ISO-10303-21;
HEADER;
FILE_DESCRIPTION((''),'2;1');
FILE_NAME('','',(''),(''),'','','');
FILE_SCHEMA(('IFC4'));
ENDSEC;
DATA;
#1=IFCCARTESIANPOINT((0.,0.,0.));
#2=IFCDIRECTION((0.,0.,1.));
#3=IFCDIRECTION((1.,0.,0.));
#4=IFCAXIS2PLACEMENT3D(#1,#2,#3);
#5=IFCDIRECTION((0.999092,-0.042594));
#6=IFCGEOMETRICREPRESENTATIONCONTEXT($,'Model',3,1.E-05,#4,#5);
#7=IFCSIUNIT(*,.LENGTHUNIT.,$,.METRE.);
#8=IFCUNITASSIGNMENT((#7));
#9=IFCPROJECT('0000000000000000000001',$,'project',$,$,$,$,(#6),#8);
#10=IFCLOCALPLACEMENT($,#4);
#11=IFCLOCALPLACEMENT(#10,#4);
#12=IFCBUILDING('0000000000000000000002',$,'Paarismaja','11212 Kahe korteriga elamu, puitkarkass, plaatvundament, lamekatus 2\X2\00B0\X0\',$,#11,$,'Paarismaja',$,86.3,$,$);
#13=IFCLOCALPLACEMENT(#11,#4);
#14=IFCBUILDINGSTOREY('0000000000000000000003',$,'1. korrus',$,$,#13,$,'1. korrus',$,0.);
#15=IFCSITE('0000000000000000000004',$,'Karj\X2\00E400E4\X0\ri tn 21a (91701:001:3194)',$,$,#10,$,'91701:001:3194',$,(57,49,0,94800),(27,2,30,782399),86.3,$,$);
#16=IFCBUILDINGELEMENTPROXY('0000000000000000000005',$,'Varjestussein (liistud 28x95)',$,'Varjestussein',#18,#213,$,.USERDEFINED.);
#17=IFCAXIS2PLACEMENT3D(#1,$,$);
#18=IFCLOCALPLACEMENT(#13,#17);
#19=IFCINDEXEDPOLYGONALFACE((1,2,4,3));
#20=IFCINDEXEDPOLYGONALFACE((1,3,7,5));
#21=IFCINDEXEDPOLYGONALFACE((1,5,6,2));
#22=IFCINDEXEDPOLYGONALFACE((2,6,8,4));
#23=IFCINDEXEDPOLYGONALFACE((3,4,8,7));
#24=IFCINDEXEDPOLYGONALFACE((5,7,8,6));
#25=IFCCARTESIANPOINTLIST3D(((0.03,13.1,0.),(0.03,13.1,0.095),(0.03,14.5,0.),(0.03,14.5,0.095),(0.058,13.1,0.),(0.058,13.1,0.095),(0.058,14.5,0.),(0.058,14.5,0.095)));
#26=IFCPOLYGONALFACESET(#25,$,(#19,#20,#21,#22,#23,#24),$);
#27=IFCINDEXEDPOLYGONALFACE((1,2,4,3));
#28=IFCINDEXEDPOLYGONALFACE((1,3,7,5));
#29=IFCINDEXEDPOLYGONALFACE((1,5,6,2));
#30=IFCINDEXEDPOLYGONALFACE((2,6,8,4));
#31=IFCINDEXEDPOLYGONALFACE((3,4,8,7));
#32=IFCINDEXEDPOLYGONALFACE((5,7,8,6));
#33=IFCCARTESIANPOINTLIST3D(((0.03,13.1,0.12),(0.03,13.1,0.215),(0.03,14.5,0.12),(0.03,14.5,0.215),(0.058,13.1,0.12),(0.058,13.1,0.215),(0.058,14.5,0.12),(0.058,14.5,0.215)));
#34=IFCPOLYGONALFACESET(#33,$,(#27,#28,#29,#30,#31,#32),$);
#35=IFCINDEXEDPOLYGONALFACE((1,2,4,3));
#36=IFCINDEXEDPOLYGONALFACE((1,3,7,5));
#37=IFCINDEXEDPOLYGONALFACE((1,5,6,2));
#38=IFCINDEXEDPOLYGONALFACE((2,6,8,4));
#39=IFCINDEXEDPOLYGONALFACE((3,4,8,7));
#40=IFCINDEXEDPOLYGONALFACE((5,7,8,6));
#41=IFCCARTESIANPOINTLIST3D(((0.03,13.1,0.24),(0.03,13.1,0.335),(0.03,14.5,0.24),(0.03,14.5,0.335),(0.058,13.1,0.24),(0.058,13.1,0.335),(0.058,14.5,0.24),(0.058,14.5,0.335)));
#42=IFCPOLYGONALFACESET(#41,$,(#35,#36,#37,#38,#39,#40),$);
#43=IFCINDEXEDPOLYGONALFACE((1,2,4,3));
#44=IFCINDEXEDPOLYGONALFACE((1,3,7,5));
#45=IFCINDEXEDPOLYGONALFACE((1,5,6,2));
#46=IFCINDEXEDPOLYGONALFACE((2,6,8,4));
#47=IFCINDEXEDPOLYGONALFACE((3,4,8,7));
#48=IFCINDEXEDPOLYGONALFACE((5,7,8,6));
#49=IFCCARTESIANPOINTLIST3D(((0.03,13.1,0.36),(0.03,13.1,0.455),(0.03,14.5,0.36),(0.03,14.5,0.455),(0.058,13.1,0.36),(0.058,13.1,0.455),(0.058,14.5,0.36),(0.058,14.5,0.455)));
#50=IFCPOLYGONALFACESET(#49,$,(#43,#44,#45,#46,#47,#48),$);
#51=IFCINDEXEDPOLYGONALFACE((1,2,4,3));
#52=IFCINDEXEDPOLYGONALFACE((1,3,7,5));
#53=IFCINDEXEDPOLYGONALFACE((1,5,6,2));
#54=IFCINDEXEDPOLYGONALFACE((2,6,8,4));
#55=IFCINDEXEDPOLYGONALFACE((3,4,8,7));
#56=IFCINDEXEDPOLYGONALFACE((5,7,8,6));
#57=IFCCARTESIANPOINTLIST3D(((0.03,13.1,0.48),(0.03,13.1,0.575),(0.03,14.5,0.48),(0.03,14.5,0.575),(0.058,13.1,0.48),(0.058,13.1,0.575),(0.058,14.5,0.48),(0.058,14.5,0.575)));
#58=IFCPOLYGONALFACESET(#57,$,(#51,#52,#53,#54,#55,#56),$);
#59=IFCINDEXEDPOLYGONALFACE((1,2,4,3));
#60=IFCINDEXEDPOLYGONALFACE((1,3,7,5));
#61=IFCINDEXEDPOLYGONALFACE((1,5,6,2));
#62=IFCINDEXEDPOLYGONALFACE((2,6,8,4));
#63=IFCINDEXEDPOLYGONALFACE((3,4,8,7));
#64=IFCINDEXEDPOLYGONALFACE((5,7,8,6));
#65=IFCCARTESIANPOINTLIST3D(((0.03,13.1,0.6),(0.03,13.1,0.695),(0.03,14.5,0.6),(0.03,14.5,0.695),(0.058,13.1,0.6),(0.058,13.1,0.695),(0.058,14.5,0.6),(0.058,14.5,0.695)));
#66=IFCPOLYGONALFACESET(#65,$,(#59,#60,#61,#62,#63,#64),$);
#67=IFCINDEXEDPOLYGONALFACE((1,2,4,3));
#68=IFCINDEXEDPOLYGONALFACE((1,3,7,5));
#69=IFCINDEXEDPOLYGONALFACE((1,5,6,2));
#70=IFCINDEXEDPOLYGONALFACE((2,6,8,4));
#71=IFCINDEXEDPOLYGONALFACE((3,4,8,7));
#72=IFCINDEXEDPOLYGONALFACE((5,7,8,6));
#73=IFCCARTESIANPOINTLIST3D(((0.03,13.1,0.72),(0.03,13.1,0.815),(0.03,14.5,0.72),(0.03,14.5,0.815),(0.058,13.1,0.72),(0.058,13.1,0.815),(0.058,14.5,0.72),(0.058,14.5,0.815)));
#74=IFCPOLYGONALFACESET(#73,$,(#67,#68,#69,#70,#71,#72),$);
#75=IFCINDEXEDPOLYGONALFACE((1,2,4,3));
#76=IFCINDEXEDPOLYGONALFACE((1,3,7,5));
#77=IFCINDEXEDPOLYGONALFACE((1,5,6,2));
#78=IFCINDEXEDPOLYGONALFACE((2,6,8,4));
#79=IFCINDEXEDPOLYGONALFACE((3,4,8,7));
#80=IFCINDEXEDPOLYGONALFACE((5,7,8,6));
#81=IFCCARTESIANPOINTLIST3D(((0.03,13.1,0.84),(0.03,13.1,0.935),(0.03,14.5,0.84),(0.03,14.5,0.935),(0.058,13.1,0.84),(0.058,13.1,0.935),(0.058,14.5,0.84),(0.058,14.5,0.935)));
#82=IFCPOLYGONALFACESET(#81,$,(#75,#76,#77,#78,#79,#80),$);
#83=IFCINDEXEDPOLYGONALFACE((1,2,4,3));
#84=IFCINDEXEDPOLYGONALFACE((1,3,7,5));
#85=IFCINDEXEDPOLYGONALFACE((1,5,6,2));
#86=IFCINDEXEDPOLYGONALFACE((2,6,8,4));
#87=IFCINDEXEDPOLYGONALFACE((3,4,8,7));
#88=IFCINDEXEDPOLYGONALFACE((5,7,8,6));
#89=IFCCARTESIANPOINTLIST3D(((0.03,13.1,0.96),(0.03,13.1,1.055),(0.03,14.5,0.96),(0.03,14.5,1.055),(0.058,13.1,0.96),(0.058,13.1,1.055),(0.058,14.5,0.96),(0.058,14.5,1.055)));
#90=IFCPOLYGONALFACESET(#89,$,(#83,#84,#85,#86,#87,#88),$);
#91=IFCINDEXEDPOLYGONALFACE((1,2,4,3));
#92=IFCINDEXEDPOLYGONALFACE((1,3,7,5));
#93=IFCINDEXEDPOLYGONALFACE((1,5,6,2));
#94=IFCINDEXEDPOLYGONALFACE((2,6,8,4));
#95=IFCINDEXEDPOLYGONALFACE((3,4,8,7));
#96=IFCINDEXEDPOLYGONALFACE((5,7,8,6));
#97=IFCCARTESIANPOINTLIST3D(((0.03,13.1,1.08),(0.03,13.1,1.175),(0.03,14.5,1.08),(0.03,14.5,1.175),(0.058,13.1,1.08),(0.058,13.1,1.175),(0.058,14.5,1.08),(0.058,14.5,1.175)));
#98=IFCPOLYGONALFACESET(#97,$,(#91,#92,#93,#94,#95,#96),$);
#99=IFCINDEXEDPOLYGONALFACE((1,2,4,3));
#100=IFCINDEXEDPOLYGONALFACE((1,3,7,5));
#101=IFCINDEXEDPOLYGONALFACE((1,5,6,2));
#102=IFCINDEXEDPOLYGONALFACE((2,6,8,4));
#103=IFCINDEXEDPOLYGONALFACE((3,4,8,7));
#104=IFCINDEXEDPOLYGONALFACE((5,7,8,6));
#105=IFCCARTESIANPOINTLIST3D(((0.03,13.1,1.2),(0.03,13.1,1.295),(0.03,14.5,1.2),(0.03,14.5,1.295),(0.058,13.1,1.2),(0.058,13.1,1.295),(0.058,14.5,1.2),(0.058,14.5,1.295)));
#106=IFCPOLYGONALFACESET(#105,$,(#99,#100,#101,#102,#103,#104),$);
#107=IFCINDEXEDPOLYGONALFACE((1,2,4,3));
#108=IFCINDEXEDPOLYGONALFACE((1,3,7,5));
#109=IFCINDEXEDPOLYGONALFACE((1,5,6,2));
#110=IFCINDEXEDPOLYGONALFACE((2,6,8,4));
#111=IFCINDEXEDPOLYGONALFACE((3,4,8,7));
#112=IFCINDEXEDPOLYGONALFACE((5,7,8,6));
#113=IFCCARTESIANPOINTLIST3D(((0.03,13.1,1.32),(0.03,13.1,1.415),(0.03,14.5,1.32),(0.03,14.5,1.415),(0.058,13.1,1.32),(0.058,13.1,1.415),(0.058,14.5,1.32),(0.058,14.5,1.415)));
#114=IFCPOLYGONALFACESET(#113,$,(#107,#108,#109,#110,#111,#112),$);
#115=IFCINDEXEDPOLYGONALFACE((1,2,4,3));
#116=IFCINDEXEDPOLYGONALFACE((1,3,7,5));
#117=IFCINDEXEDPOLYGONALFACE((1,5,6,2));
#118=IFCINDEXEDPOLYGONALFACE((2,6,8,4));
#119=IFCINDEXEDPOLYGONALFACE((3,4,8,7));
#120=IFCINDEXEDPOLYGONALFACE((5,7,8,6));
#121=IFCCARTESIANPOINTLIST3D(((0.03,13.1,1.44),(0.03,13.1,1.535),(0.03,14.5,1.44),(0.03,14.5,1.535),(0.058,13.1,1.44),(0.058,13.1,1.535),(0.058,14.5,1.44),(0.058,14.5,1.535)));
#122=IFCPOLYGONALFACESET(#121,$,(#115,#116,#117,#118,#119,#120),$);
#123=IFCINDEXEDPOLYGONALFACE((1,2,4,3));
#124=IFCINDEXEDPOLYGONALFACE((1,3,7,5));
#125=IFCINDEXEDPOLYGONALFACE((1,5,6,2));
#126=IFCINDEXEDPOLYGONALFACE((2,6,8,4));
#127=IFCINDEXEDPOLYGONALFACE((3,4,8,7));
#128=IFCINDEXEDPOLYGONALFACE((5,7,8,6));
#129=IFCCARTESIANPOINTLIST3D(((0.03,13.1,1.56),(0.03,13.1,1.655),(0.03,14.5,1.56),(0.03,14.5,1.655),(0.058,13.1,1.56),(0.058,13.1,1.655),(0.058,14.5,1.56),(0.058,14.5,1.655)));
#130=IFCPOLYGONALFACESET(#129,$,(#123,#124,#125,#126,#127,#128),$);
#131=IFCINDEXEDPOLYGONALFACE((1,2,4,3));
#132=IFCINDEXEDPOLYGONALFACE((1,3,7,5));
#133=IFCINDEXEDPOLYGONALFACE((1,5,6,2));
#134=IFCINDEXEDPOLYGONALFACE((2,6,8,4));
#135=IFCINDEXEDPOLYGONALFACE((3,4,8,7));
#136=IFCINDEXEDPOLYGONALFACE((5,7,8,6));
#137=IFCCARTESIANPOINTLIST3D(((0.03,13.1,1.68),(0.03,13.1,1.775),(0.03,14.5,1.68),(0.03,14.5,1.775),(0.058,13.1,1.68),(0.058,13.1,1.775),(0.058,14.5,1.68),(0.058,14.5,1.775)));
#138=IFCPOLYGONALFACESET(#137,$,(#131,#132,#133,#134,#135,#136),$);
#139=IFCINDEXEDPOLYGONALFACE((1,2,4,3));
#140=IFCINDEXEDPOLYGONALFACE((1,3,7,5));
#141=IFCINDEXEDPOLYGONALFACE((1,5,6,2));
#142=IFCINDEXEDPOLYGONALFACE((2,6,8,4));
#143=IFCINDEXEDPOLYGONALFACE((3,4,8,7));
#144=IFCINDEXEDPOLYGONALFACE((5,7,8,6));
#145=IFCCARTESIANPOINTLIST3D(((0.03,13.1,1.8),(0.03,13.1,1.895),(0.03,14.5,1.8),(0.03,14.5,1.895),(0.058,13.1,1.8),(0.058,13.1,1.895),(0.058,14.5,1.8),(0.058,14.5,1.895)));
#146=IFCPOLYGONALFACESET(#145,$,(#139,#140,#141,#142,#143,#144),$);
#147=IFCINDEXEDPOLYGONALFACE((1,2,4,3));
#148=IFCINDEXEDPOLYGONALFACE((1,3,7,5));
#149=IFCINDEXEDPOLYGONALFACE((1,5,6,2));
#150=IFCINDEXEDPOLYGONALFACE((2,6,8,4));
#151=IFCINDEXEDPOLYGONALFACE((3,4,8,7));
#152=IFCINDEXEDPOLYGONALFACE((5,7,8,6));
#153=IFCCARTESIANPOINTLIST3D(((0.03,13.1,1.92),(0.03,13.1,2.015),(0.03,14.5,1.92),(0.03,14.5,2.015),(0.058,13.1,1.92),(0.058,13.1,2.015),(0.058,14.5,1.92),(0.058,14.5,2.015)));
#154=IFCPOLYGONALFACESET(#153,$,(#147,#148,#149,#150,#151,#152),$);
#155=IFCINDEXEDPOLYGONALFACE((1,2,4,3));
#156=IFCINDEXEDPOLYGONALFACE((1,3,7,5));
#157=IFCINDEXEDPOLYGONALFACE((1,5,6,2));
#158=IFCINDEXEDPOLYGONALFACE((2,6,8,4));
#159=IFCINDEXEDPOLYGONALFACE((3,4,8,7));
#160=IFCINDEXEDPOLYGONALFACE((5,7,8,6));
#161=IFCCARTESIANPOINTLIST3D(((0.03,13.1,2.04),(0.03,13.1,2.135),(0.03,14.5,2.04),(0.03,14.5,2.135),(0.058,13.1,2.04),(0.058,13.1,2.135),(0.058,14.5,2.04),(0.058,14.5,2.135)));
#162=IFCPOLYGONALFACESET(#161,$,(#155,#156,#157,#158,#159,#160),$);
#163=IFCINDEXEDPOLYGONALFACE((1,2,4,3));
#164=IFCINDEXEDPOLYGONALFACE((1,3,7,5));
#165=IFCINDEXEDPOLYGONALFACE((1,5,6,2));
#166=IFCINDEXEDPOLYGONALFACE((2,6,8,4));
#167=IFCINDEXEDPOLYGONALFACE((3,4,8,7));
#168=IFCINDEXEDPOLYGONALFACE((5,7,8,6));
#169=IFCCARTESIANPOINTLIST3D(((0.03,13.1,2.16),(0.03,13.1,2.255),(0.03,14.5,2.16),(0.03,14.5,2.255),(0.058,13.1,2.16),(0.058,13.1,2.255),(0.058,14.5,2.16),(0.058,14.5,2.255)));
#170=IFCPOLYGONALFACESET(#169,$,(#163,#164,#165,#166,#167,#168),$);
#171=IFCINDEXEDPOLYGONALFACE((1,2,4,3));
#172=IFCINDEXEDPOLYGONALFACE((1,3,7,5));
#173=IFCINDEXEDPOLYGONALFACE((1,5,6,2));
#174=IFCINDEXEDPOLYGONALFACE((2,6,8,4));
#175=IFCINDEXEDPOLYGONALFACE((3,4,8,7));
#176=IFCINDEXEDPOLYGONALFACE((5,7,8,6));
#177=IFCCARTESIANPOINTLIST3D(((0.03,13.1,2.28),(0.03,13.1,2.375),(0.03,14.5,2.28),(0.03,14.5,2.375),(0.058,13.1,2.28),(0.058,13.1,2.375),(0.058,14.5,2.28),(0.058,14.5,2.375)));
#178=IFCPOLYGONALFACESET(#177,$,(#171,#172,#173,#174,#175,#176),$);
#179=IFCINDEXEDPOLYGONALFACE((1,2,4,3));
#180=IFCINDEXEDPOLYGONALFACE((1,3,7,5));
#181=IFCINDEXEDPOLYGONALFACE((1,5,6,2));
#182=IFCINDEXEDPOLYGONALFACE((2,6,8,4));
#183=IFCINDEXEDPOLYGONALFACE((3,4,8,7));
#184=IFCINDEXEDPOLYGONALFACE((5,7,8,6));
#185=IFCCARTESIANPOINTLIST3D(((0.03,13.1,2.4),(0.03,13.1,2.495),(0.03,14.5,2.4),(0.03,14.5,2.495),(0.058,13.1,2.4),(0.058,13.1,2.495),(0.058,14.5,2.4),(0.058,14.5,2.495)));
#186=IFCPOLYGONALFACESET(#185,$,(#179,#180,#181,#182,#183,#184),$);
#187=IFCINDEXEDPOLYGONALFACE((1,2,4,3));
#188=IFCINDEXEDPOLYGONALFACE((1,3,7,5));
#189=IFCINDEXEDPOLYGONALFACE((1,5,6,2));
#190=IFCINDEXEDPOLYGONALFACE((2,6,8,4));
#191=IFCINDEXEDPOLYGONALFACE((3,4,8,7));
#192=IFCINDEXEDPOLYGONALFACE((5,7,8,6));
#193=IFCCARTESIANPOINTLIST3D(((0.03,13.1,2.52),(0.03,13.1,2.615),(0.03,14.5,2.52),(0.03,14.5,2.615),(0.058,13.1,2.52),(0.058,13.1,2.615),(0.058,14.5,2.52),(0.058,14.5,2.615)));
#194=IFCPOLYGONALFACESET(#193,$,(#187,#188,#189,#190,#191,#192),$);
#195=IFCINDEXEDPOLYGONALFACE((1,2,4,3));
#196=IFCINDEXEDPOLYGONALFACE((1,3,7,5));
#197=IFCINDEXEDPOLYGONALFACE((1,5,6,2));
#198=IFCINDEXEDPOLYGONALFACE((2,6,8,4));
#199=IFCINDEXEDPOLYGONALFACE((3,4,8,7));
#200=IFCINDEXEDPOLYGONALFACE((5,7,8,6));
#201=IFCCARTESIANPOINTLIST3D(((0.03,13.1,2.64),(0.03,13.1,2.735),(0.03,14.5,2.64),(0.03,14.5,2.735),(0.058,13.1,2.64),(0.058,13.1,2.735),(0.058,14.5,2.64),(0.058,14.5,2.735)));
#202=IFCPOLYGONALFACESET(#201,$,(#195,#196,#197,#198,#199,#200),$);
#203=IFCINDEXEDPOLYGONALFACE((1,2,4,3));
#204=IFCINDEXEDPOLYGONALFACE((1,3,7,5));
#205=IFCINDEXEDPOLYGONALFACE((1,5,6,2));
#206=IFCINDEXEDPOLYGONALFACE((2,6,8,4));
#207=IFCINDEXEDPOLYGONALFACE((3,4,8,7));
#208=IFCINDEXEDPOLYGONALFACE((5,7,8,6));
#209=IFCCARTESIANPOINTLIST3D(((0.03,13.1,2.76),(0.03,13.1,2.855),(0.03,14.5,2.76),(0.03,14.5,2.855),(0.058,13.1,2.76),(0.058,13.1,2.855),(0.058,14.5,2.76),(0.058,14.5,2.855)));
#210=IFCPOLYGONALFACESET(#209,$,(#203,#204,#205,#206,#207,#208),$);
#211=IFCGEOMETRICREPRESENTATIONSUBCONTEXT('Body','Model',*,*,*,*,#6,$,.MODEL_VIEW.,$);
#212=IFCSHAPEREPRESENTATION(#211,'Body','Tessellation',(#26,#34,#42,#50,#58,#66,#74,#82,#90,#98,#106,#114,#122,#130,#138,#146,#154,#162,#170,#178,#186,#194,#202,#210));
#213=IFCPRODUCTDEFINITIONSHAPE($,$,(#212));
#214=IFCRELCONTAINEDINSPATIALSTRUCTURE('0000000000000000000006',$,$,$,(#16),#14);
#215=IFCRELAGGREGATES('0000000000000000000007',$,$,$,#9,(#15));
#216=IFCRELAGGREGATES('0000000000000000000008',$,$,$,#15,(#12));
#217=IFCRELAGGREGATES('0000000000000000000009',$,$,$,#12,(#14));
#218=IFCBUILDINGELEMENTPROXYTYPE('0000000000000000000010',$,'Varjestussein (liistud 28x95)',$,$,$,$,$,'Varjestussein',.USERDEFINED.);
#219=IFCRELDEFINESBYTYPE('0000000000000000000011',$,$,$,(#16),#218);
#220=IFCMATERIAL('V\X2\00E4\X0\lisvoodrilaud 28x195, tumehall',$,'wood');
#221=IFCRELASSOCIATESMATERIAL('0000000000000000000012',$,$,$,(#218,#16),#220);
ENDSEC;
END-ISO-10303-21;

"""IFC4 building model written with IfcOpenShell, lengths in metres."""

from ifc_helpers import new_model, si_unit, direction, frame, origin_with_axes, place, context, subcontext, project, spatial, indexed_curve, outline, extrude, material, type_object, element, save


model = new_model("IFC4")

# Units and contexts
model_context = context("Model", 3, precision=1e-05, world=origin_with_axes(), true_north=direction((0.999092, -0.042594)))
body_context = subcontext(model_context, "Body", "Model", "MODEL_VIEW")
ifc_project = project(units=[si_unit("LENGTHUNIT", "METRE")], contexts=[model_context])

# Site, building, storey
site_placement = place(None, origin_with_axes())
site = spatial("IfcSite", under=ifc_project, at=site_placement, Name="Karjääri tn 21a (91701:001:3194)", LongName="91701:001:3194", RefLatitude=(57, 49, 0, 94800), RefLongitude=(27, 2, 30, 782399), RefElevation=86.3)
building_placement = place(site_placement, origin_with_axes())
building = spatial("IfcBuilding", under=site, at=building_placement, Name="Paarismaja", Description="11212 Kahe korteriga elamu, puitkarkass, plaatvundament, lamekatus 2°", LongName="Paarismaja", ElevationOfRefHeight=86.3)
storey_placement = place(building_placement, origin_with_axes())
storey = spatial("IfcBuildingStorey", under=building, at=storey_placement, Name="1. korrus", LongName="1. korrus", Elevation=0.0)

# Building element proxy
ifc_material_1 = material(Name="Välisvoodrilaud 28x195, tumehall", Category="wood")
building_element_proxy_type_1 = type_object("IfcBuildingElementProxyType", Name="Varjestussein (liistud 28x95)", ElementType="Varjestussein", PredefinedType="USERDEFINED", material=ifc_material_1)
proxy_1_placement = place(storey_placement, origin_with_axes())
element("IfcBuildingElementProxy", 1, at=proxy_1_placement, inside=storey, type_object=building_element_proxy_type_1, material=ifc_material_1, Name="Varjestussein (liistud 28x95)", ObjectType="Varjestussein", PredefinedType="USERDEFINED", context=body_context, shape_type="SweptSolid", body=[
    extrude(outline(indexed_curve([(0.03, 13.1), (0.058, 13.1), (0.058, 14.5), (0.03, 14.5), (0.03, 13.1)], self_intersect=False)), origin_with_axes(), (0.0, 0.0, 1.0), 0.095),
    extrude(outline(indexed_curve([(0.03, 13.1), (0.058, 13.1), (0.058, 14.5), (0.03, 14.5), (0.03, 13.1)], self_intersect=False)), frame((0.0, 0.0, 0.12), z_axis=(0.0, 0.0, 1.0), x_axis=(1.0, 0.0, 0.0)), (0.0, 0.0, 1.0), 0.095),
    extrude(outline(indexed_curve([(0.03, 13.1), (0.058, 13.1), (0.058, 14.5), (0.03, 14.5), (0.03, 13.1)], self_intersect=False)), frame((0.0, 0.0, 0.24), z_axis=(0.0, 0.0, 1.0), x_axis=(1.0, 0.0, 0.0)), (0.0, 0.0, 1.0), 0.095),
    extrude(outline(indexed_curve([(0.03, 13.1), (0.058, 13.1), (0.058, 14.5), (0.03, 14.5), (0.03, 13.1)], self_intersect=False)), frame((0.0, 0.0, 0.36), z_axis=(0.0, 0.0, 1.0), x_axis=(1.0, 0.0, 0.0)), (0.0, 0.0, 1.0), 0.095),
    extrude(outline(indexed_curve([(0.03, 13.1), (0.058, 13.1), (0.058, 14.5), (0.03, 14.5), (0.03, 13.1)], self_intersect=False)), frame((0.0, 0.0, 0.48), z_axis=(0.0, 0.0, 1.0), x_axis=(1.0, 0.0, 0.0)), (0.0, 0.0, 1.0), 0.095),
    extrude(outline(indexed_curve([(0.03, 13.1), (0.058, 13.1), (0.058, 14.5), (0.03, 14.5), (0.03, 13.1)], self_intersect=False)), frame((0.0, 0.0, 0.6), z_axis=(0.0, 0.0, 1.0), x_axis=(1.0, 0.0, 0.0)), (0.0, 0.0, 1.0), 0.095),
    extrude(outline(indexed_curve([(0.03, 13.1), (0.058, 13.1), (0.058, 14.5), (0.03, 14.5), (0.03, 13.1)], self_intersect=False)), frame((0.0, 0.0, 0.72), z_axis=(0.0, 0.0, 1.0), x_axis=(1.0, 0.0, 0.0)), (0.0, 0.0, 1.0), 0.095),
    extrude(outline(indexed_curve([(0.03, 13.1), (0.058, 13.1), (0.058, 14.5), (0.03, 14.5), (0.03, 13.1)], self_intersect=False)), frame((0.0, 0.0, 0.84), z_axis=(0.0, 0.0, 1.0), x_axis=(1.0, 0.0, 0.0)), (0.0, 0.0, 1.0), 0.095),
    extrude(outline(indexed_curve([(0.03, 13.1), (0.058, 13.1), (0.058, 14.5), (0.03, 14.5), (0.03, 13.1)], self_intersect=False)), frame((0.0, 0.0, 0.96), z_axis=(0.0, 0.0, 1.0), x_axis=(1.0, 0.0, 0.0)), (0.0, 0.0, 1.0), 0.095),
    extrude(outline(indexed_curve([(0.03, 13.1), (0.058, 13.1), (0.058, 14.5), (0.03, 14.5), (0.03, 13.1)], self_intersect=False)), frame((0.0, 0.0, 1.08), z_axis=(0.0, 0.0, 1.0), x_axis=(1.0, 0.0, 0.0)), (0.0, 0.0, 1.0), 0.095),
    extrude(outline(indexed_curve([(0.03, 13.1), (0.058, 13.1), (0.058, 14.5), (0.03, 14.5), (0.03, 13.1)], self_intersect=False)), frame((0.0, 0.0, 1.2), z_axis=(0.0, 0.0, 1.0), x_axis=(1.0, 0.0, 0.0)), (0.0, 0.0, 1.0), 0.095),
    extrude(outline(indexed_curve([(0.03, 13.1), (0.058, 13.1), (0.058, 14.5), (0.03, 14.5), (0.03, 13.1)], self_intersect=False)), frame((0.0, 0.0, 1.32), z_axis=(0.0, 0.0, 1.0), x_axis=(1.0, 0.0, 0.0)), (0.0, 0.0, 1.0), 0.095),
    extrude(outline(indexed_curve([(0.03, 13.1), (0.058, 13.1), (0.058, 14.5), (0.03, 14.5), (0.03, 13.1)], self_intersect=False)), frame((0.0, 0.0, 1.44), z_axis=(0.0, 0.0, 1.0), x_axis=(1.0, 0.0, 0.0)), (0.0, 0.0, 1.0), 0.095),
    extrude(outline(indexed_curve([(0.03, 13.1), (0.058, 13.1), (0.058, 14.5), (0.03, 14.5), (0.03, 13.1)], self_intersect=False)), frame((0.0, 0.0, 1.56), z_axis=(0.0, 0.0, 1.0), x_axis=(1.0, 0.0, 0.0)), (0.0, 0.0, 1.0), 0.095),
    extrude(outline(indexed_curve([(0.03, 13.1), (0.058, 13.1), (0.058, 14.5), (0.03, 14.5), (0.03, 13.1)], self_intersect=False)), frame((0.0, 0.0, 1.68), z_axis=(0.0, 0.0, 1.0), x_axis=(1.0, 0.0, 0.0)), (0.0, 0.0, 1.0), 0.095),
    extrude(outline(indexed_curve([(0.03, 13.1), (0.058, 13.1), (0.058, 14.5), (0.03, 14.5), (0.03, 13.1)], self_intersect=False)), frame((0.0, 0.0, 1.8), z_axis=(0.0, 0.0, 1.0), x_axis=(1.0, 0.0, 0.0)), (0.0, 0.0, 1.0), 0.095),
    extrude(outline(indexed_curve([(0.03, 13.1), (0.058, 13.1), (0.058, 14.5), (0.03, 14.5), (0.03, 13.1)], self_intersect=False)), frame((0.0, 0.0, 1.92), z_axis=(0.0, 0.0, 1.0), x_axis=(1.0, 0.0, 0.0)), (0.0, 0.0, 1.0), 0.095),
    extrude(outline(indexed_curve([(0.03, 13.1), (0.058, 13.1), (0.058, 14.5), (0.03, 14.5), (0.03, 13.1)], self_intersect=False)), frame((0.0, 0.0, 2.04), z_axis=(0.0, 0.0, 1.0), x_axis=(1.0, 0.0, 0.0)), (0.0, 0.0, 1.0), 0.095),
    extrude(outline(indexed_curve([(0.03, 13.1), (0.058, 13.1), (0.058, 14.5), (0.03, 14.5), (0.03, 13.1)], self_intersect=False)), frame((0.0, 0.0, 2.16), z_axis=(0.0, 0.0, 1.0), x_axis=(1.0, 0.0, 0.0)), (0.0, 0.0, 1.0), 0.095),
    extrude(outline(indexed_curve([(0.03, 13.1), (0.058, 13.1), (0.058, 14.5), (0.03, 14.5), (0.03, 13.1)], self_intersect=False)), frame((0.0, 0.0, 2.28), z_axis=(0.0, 0.0, 1.0), x_axis=(1.0, 0.0, 0.0)), (0.0, 0.0, 1.0), 0.095),
    extrude(outline(indexed_curve([(0.03, 13.1), (0.058, 13.1), (0.058, 14.5), (0.03, 14.5), (0.03, 13.1)], self_intersect=False)), frame((0.0, 0.0, 2.4), z_axis=(0.0, 0.0, 1.0), x_axis=(1.0, 0.0, 0.0)), (0.0, 0.0, 1.0), 0.095),
    extrude(outline(indexed_curve([(0.03, 13.1), (0.058, 13.1), (0.058, 14.5), (0.03, 14.5), (0.03, 13.1)], self_intersect=False)), frame((0.0, 0.0, 2.52), z_axis=(0.0, 0.0, 1.0), x_axis=(1.0, 0.0, 0.0)), (0.0, 0.0, 1.0), 0.095),
    extrude(outline(indexed_curve([(0.03, 13.1), (0.058, 13.1), (0.058, 14.5), (0.03, 14.5), (0.03, 13.1)], self_intersect=False)), frame((0.0, 0.0, 2.64), z_axis=(0.0, 0.0, 1.0), x_axis=(1.0, 0.0, 0.0)), (0.0, 0.0, 1.0), 0.095),
    extrude(outline(indexed_curve([(0.03, 13.1), (0.058, 13.1), (0.058, 14.5), (0.03, 14.5), (0.03, 13.1)], self_intersect=False)), frame((0.0, 0.0, 2.76), z_axis=(0.0, 0.0, 1.0), x_axis=(1.0, 0.0, 0.0)), (0.0, 0.0, 1.0), 0.095),
])

save(model, "model.ifc")
